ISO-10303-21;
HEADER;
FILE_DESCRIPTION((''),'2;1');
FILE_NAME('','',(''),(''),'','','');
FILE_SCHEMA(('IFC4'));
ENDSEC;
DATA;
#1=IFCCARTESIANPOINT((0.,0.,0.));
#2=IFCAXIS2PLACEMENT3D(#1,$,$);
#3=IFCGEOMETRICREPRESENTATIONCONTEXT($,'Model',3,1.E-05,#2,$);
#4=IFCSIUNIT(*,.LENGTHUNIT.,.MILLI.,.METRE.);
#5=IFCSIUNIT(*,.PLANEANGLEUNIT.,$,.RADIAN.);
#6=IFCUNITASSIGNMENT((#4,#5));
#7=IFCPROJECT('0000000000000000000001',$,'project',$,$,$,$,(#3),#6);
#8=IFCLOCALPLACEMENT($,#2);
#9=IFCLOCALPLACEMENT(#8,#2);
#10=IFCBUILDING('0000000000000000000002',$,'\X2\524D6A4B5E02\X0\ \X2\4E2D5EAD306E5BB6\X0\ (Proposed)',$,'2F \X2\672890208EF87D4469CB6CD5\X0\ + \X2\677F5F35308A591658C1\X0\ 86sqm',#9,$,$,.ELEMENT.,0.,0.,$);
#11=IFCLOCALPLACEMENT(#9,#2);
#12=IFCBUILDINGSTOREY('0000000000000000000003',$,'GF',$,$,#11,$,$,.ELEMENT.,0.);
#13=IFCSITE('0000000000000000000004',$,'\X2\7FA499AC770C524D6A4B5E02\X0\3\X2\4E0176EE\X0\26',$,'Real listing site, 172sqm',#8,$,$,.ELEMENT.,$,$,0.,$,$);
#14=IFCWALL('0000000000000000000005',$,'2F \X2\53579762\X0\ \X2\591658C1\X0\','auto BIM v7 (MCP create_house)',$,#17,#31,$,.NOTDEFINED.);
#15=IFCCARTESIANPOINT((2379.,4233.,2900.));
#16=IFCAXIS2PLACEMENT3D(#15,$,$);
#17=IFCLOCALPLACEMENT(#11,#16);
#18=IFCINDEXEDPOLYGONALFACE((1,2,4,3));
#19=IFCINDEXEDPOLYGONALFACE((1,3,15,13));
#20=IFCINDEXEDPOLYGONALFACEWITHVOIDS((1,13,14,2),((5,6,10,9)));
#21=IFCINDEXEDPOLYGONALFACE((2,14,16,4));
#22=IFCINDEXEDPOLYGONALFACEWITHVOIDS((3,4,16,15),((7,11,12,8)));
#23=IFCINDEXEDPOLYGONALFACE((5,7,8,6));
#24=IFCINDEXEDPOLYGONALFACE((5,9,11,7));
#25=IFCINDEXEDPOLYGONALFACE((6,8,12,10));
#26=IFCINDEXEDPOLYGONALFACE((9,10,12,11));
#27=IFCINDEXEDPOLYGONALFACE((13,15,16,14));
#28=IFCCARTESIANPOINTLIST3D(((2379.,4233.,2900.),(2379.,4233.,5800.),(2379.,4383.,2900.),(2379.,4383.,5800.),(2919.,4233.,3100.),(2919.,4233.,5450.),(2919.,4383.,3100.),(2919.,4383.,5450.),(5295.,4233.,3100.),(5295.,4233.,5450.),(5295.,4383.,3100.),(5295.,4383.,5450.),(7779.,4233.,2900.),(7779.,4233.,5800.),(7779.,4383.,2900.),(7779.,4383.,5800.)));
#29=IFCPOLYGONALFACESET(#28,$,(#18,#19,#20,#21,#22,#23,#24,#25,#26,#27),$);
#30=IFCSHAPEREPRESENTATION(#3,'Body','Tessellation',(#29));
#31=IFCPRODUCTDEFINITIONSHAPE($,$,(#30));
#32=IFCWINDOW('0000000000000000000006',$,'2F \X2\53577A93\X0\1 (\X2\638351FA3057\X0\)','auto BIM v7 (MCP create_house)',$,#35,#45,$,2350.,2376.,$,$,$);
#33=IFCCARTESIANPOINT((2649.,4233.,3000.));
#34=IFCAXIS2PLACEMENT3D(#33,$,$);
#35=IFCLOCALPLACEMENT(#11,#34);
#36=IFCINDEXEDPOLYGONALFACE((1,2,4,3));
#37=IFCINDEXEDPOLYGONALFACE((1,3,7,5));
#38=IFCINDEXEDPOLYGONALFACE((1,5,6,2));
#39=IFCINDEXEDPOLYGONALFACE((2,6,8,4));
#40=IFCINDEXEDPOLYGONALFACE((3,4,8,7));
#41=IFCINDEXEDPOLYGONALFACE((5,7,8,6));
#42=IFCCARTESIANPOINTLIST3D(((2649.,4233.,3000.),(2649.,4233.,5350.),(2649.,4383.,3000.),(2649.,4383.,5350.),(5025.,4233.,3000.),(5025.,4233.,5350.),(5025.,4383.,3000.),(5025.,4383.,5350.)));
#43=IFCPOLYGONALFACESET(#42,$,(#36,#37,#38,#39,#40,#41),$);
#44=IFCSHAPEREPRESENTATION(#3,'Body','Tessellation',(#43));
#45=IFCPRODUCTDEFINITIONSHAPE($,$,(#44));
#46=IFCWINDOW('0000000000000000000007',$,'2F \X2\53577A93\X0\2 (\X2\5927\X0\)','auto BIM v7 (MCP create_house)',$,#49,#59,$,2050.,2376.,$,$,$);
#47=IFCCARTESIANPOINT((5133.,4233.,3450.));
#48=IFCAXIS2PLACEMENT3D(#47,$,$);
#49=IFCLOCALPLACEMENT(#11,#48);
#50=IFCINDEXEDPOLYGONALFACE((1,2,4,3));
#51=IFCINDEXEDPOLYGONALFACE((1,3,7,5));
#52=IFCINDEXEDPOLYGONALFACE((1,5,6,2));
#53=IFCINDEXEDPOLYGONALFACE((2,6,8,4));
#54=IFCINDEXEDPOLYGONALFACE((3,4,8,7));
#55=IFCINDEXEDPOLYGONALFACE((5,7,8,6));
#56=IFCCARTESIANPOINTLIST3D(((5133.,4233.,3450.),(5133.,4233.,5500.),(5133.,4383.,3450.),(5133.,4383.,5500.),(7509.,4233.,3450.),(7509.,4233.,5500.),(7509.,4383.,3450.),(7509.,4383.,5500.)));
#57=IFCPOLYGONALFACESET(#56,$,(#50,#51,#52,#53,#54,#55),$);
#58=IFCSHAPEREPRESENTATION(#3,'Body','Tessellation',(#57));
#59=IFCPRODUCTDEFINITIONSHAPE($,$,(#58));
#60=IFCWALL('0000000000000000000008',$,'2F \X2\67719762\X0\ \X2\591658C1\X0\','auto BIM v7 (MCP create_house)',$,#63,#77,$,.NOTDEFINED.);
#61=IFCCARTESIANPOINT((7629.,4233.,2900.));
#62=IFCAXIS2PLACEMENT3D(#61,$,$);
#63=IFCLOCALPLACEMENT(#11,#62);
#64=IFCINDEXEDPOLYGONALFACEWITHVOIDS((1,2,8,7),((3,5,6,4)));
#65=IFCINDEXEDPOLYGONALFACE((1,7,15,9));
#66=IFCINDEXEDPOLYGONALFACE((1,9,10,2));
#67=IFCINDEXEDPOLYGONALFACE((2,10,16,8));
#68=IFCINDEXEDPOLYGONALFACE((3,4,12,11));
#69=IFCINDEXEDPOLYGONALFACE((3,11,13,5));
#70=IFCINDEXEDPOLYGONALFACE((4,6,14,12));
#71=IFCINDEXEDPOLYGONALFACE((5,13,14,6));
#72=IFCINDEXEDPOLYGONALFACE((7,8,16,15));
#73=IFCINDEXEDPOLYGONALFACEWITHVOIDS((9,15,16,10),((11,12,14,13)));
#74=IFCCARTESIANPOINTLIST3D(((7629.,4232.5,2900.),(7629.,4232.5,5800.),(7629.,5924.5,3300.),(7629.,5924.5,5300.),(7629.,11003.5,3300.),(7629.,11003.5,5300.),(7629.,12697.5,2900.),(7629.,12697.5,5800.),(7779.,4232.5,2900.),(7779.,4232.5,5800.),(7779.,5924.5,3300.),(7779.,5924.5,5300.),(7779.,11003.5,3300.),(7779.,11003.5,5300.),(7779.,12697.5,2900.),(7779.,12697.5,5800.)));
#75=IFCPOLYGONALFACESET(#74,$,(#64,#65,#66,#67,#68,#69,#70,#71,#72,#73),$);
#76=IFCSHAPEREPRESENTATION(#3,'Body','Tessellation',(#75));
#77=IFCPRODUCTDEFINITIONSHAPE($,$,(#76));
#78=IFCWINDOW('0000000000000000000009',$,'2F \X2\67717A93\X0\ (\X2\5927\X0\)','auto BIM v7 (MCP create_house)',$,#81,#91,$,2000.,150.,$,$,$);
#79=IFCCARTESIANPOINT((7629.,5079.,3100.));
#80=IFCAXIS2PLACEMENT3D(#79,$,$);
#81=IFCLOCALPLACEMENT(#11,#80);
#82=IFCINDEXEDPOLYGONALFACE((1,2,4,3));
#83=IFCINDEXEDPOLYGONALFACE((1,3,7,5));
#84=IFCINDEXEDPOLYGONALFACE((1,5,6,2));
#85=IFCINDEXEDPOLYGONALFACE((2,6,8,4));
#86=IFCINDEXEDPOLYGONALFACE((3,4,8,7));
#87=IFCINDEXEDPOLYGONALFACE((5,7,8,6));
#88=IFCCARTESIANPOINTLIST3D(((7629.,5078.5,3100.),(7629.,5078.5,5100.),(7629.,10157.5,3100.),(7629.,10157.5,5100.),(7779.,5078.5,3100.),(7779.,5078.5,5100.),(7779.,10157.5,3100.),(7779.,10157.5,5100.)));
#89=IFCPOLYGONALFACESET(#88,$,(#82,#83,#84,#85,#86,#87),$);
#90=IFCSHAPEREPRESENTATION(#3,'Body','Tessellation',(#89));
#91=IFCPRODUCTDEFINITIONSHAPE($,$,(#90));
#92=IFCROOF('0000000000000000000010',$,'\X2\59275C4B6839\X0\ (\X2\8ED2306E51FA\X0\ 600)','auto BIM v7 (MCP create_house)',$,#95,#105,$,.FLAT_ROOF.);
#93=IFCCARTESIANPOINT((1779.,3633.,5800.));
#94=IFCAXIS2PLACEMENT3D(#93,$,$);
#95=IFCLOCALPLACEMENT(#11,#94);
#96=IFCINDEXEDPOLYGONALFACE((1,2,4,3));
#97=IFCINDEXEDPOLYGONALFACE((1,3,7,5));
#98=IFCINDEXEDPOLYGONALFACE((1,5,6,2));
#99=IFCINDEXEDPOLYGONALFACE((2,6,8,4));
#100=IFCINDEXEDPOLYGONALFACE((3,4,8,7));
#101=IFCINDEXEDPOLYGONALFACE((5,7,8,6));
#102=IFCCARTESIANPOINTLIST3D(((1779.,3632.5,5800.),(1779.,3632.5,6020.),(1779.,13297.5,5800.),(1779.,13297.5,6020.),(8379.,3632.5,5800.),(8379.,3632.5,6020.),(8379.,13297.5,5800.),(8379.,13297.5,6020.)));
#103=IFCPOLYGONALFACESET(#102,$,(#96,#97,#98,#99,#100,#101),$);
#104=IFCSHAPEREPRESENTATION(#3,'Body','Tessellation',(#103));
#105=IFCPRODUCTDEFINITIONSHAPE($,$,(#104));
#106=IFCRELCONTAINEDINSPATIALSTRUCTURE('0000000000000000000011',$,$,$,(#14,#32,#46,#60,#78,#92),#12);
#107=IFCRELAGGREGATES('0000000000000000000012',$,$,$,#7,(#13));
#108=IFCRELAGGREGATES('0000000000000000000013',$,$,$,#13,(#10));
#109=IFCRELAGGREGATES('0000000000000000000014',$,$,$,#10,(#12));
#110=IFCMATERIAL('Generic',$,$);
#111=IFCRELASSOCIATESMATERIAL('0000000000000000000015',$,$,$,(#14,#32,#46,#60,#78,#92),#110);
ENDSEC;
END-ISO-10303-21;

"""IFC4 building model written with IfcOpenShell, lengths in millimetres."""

from ifc_helpers import new_model, si_unit, frame, frame_2d, origin, place, context, project, spatial, rectangle, extrude, material, element, fill, save


model = new_model("IFC4")

# Units and contexts
model_context = context("Model", 3, precision=1e-05, world=origin())
ifc_project = project(units=[si_unit("LENGTHUNIT", "METRE", prefix="MILLI"), si_unit("PLANEANGLEUNIT", "RADIAN")], contexts=[model_context])

# Site, building, storey
site_placement = place(None, origin())
site = spatial("IfcSite", under=ifc_project, at=site_placement, Name="群馬県前橋市3丁目26", ObjectType="Real listing site, 172sqm", CompositionType="ELEMENT", RefElevation=0.0)
building_placement = place(site_placement, origin())
building = spatial("IfcBuilding", under=site, at=building_placement, Name="前橋市 中庭の家 (Proposed)", ObjectType="2F 木造軸組構法 + 板張り外壁 86sqm", CompositionType="ELEMENT", ElevationOfRefHeight=0.0, ElevationOfTerrain=0.0)
storey_placement = place(building_placement, origin())
storey = spatial("IfcBuildingStorey", under=building, at=storey_placement, Name="GF", CompositionType="ELEMENT", Elevation=0.0)

# Shared definitions
ifc_material = material(Name="Generic")

# Wall, openings, windows
wall_1_placement = place(storey_placement, frame((2379.0, 4233.0, 2900.0)))
wall_1 = element("IfcWall", 1, at=wall_1_placement, inside=storey, material=ifc_material, Name="2F 南面 外壁", Description="auto BIM v7 (MCP create_house)", PredefinedType="NOTDEFINED", context=model_context, shape_type="SweptSolid", body=[
    extrude(rectangle(XDim=5400.0, YDim=150.0, at=frame_2d((2700.0, 75.0))), frame((2379.0, 4233.0, 2900.0)), (0.0, 0.0, 1.0), 2900.0),
])
opening_1_placement = place(storey_placement, frame((2649.0, 4233.0, 3000.0)))
opening_1 = element("IfcOpeningElement", 2, at=opening_1_placement, cuts=wall_1, PredefinedType="NOTDEFINED", context=model_context, shape_type="SweptSolid", body=[
    extrude(rectangle(XDim=2376.0, YDim=150.0, at=frame_2d((1188.0, 75.0))), frame((2649.0, 4233.0, 3000.0)), (0.0, 0.0, 1.0), 2350.0),
])
opening_2_placement = place(storey_placement, frame((5133.0, 4233.0, 3450.0)))
opening_2 = element("IfcOpeningElement", 3, at=opening_2_placement, cuts=wall_1, PredefinedType="NOTDEFINED", context=model_context, shape_type="SweptSolid", body=[
    extrude(rectangle(XDim=2376.0, YDim=150.0, at=frame_2d((1188.0, 75.0))), frame((5133.0, 4233.0, 3450.0)), (0.0, 0.0, 1.0), 2050.0),
])
window_1_placement = place(storey_placement, frame((2649.0, 4233.0, 3000.0)))
window_1 = element("IfcWindow", 4, at=window_1_placement, inside=storey, material=ifc_material, Name="2F 南窓1 (掃出し)", Description="auto BIM v7 (MCP create_house)", OverallHeight=2350.0, OverallWidth=2376.0, context=model_context, shape_type="SweptSolid", body=[
    extrude(rectangle(XDim=2376.0, YDim=150.0, at=frame_2d((1188.0, 75.0))), frame((2649.0, 4233.0, 3000.0)), (0.0, 0.0, 1.0), 2350.0),
])
fill(opening_1, window_1)
window_2_placement = place(storey_placement, frame((5133.0, 4233.0, 3450.0)))
window_2 = element("IfcWindow", 5, at=window_2_placement, inside=storey, material=ifc_material, Name="2F 南窓2 (大)", Description="auto BIM v7 (MCP create_house)", OverallHeight=2050.0, OverallWidth=2376.0, context=model_context, shape_type="SweptSolid", body=[
    extrude(rectangle(XDim=2376.0, YDim=150.0, at=frame_2d((1188.0, 75.0))), frame((5133.0, 4233.0, 3450.0)), (0.0, 0.0, 1.0), 2050.0),
])
fill(opening_2, window_2)

# Wall, opening, window
wall_2_placement = place(storey_placement, frame((7629.0, 4233.0, 2900.0)))
wall_2 = element("IfcWall", 6, at=wall_2_placement, inside=storey, material=ifc_material, Name="2F 東面 外壁", Description="auto BIM v7 (MCP create_house)", PredefinedType="NOTDEFINED", context=model_context, shape_type="SweptSolid", body=[
    extrude(rectangle(XDim=150.0, YDim=8465.0, at=frame_2d((75.0, 4232.0))), frame((7629.0, 4233.0, 2900.0)), (0.0, 0.0, 1.0), 2900.0),
])
opening_3_placement = place(storey_placement, frame((7629.0, 5079.0, 3100.0)))
opening_3 = element("IfcOpeningElement", 7, at=opening_3_placement, cuts=wall_2, PredefinedType="NOTDEFINED", context=model_context, shape_type="SweptSolid", body=[
    extrude(rectangle(XDim=150.0, YDim=5079.0, at=frame_2d((75.0, 2539.0))), frame((7629.0, 5079.0, 3100.0)), (0.0, 0.0, 1.0), 2000.0),
])
window_3_placement = place(storey_placement, frame((7629.0, 5079.0, 3100.0)))
window_3 = element("IfcWindow", 8, at=window_3_placement, inside=storey, material=ifc_material, Name="2F 東窓 (大)", Description="auto BIM v7 (MCP create_house)", OverallHeight=2000.0, OverallWidth=150.0, context=model_context, shape_type="SweptSolid", body=[
    extrude(rectangle(XDim=150.0, YDim=5079.0, at=frame_2d((75.0, 2539.0))), frame((7629.0, 5079.0, 3100.0)), (0.0, 0.0, 1.0), 2000.0),
])
fill(opening_3, window_3)

# Roof
roof_placement = place(storey_placement, frame((1779.0, 3633.0, 5800.0)))
element("IfcRoof", 9, at=roof_placement, inside=storey, material=ifc_material, Name="大屋根 (軒の出 600)", Description="auto BIM v7 (MCP create_house)", PredefinedType="FLAT_ROOF", context=model_context, shape_type="SweptSolid", body=[
    extrude(rectangle(XDim=6600.0, YDim=9665.0, at=frame_2d((3300.0, 4832.0))), frame((1779.0, 3633.0, 5800.0)), (0.0, 0.0, 1.0), 220.0),
])

save(model, "model.ifc")
